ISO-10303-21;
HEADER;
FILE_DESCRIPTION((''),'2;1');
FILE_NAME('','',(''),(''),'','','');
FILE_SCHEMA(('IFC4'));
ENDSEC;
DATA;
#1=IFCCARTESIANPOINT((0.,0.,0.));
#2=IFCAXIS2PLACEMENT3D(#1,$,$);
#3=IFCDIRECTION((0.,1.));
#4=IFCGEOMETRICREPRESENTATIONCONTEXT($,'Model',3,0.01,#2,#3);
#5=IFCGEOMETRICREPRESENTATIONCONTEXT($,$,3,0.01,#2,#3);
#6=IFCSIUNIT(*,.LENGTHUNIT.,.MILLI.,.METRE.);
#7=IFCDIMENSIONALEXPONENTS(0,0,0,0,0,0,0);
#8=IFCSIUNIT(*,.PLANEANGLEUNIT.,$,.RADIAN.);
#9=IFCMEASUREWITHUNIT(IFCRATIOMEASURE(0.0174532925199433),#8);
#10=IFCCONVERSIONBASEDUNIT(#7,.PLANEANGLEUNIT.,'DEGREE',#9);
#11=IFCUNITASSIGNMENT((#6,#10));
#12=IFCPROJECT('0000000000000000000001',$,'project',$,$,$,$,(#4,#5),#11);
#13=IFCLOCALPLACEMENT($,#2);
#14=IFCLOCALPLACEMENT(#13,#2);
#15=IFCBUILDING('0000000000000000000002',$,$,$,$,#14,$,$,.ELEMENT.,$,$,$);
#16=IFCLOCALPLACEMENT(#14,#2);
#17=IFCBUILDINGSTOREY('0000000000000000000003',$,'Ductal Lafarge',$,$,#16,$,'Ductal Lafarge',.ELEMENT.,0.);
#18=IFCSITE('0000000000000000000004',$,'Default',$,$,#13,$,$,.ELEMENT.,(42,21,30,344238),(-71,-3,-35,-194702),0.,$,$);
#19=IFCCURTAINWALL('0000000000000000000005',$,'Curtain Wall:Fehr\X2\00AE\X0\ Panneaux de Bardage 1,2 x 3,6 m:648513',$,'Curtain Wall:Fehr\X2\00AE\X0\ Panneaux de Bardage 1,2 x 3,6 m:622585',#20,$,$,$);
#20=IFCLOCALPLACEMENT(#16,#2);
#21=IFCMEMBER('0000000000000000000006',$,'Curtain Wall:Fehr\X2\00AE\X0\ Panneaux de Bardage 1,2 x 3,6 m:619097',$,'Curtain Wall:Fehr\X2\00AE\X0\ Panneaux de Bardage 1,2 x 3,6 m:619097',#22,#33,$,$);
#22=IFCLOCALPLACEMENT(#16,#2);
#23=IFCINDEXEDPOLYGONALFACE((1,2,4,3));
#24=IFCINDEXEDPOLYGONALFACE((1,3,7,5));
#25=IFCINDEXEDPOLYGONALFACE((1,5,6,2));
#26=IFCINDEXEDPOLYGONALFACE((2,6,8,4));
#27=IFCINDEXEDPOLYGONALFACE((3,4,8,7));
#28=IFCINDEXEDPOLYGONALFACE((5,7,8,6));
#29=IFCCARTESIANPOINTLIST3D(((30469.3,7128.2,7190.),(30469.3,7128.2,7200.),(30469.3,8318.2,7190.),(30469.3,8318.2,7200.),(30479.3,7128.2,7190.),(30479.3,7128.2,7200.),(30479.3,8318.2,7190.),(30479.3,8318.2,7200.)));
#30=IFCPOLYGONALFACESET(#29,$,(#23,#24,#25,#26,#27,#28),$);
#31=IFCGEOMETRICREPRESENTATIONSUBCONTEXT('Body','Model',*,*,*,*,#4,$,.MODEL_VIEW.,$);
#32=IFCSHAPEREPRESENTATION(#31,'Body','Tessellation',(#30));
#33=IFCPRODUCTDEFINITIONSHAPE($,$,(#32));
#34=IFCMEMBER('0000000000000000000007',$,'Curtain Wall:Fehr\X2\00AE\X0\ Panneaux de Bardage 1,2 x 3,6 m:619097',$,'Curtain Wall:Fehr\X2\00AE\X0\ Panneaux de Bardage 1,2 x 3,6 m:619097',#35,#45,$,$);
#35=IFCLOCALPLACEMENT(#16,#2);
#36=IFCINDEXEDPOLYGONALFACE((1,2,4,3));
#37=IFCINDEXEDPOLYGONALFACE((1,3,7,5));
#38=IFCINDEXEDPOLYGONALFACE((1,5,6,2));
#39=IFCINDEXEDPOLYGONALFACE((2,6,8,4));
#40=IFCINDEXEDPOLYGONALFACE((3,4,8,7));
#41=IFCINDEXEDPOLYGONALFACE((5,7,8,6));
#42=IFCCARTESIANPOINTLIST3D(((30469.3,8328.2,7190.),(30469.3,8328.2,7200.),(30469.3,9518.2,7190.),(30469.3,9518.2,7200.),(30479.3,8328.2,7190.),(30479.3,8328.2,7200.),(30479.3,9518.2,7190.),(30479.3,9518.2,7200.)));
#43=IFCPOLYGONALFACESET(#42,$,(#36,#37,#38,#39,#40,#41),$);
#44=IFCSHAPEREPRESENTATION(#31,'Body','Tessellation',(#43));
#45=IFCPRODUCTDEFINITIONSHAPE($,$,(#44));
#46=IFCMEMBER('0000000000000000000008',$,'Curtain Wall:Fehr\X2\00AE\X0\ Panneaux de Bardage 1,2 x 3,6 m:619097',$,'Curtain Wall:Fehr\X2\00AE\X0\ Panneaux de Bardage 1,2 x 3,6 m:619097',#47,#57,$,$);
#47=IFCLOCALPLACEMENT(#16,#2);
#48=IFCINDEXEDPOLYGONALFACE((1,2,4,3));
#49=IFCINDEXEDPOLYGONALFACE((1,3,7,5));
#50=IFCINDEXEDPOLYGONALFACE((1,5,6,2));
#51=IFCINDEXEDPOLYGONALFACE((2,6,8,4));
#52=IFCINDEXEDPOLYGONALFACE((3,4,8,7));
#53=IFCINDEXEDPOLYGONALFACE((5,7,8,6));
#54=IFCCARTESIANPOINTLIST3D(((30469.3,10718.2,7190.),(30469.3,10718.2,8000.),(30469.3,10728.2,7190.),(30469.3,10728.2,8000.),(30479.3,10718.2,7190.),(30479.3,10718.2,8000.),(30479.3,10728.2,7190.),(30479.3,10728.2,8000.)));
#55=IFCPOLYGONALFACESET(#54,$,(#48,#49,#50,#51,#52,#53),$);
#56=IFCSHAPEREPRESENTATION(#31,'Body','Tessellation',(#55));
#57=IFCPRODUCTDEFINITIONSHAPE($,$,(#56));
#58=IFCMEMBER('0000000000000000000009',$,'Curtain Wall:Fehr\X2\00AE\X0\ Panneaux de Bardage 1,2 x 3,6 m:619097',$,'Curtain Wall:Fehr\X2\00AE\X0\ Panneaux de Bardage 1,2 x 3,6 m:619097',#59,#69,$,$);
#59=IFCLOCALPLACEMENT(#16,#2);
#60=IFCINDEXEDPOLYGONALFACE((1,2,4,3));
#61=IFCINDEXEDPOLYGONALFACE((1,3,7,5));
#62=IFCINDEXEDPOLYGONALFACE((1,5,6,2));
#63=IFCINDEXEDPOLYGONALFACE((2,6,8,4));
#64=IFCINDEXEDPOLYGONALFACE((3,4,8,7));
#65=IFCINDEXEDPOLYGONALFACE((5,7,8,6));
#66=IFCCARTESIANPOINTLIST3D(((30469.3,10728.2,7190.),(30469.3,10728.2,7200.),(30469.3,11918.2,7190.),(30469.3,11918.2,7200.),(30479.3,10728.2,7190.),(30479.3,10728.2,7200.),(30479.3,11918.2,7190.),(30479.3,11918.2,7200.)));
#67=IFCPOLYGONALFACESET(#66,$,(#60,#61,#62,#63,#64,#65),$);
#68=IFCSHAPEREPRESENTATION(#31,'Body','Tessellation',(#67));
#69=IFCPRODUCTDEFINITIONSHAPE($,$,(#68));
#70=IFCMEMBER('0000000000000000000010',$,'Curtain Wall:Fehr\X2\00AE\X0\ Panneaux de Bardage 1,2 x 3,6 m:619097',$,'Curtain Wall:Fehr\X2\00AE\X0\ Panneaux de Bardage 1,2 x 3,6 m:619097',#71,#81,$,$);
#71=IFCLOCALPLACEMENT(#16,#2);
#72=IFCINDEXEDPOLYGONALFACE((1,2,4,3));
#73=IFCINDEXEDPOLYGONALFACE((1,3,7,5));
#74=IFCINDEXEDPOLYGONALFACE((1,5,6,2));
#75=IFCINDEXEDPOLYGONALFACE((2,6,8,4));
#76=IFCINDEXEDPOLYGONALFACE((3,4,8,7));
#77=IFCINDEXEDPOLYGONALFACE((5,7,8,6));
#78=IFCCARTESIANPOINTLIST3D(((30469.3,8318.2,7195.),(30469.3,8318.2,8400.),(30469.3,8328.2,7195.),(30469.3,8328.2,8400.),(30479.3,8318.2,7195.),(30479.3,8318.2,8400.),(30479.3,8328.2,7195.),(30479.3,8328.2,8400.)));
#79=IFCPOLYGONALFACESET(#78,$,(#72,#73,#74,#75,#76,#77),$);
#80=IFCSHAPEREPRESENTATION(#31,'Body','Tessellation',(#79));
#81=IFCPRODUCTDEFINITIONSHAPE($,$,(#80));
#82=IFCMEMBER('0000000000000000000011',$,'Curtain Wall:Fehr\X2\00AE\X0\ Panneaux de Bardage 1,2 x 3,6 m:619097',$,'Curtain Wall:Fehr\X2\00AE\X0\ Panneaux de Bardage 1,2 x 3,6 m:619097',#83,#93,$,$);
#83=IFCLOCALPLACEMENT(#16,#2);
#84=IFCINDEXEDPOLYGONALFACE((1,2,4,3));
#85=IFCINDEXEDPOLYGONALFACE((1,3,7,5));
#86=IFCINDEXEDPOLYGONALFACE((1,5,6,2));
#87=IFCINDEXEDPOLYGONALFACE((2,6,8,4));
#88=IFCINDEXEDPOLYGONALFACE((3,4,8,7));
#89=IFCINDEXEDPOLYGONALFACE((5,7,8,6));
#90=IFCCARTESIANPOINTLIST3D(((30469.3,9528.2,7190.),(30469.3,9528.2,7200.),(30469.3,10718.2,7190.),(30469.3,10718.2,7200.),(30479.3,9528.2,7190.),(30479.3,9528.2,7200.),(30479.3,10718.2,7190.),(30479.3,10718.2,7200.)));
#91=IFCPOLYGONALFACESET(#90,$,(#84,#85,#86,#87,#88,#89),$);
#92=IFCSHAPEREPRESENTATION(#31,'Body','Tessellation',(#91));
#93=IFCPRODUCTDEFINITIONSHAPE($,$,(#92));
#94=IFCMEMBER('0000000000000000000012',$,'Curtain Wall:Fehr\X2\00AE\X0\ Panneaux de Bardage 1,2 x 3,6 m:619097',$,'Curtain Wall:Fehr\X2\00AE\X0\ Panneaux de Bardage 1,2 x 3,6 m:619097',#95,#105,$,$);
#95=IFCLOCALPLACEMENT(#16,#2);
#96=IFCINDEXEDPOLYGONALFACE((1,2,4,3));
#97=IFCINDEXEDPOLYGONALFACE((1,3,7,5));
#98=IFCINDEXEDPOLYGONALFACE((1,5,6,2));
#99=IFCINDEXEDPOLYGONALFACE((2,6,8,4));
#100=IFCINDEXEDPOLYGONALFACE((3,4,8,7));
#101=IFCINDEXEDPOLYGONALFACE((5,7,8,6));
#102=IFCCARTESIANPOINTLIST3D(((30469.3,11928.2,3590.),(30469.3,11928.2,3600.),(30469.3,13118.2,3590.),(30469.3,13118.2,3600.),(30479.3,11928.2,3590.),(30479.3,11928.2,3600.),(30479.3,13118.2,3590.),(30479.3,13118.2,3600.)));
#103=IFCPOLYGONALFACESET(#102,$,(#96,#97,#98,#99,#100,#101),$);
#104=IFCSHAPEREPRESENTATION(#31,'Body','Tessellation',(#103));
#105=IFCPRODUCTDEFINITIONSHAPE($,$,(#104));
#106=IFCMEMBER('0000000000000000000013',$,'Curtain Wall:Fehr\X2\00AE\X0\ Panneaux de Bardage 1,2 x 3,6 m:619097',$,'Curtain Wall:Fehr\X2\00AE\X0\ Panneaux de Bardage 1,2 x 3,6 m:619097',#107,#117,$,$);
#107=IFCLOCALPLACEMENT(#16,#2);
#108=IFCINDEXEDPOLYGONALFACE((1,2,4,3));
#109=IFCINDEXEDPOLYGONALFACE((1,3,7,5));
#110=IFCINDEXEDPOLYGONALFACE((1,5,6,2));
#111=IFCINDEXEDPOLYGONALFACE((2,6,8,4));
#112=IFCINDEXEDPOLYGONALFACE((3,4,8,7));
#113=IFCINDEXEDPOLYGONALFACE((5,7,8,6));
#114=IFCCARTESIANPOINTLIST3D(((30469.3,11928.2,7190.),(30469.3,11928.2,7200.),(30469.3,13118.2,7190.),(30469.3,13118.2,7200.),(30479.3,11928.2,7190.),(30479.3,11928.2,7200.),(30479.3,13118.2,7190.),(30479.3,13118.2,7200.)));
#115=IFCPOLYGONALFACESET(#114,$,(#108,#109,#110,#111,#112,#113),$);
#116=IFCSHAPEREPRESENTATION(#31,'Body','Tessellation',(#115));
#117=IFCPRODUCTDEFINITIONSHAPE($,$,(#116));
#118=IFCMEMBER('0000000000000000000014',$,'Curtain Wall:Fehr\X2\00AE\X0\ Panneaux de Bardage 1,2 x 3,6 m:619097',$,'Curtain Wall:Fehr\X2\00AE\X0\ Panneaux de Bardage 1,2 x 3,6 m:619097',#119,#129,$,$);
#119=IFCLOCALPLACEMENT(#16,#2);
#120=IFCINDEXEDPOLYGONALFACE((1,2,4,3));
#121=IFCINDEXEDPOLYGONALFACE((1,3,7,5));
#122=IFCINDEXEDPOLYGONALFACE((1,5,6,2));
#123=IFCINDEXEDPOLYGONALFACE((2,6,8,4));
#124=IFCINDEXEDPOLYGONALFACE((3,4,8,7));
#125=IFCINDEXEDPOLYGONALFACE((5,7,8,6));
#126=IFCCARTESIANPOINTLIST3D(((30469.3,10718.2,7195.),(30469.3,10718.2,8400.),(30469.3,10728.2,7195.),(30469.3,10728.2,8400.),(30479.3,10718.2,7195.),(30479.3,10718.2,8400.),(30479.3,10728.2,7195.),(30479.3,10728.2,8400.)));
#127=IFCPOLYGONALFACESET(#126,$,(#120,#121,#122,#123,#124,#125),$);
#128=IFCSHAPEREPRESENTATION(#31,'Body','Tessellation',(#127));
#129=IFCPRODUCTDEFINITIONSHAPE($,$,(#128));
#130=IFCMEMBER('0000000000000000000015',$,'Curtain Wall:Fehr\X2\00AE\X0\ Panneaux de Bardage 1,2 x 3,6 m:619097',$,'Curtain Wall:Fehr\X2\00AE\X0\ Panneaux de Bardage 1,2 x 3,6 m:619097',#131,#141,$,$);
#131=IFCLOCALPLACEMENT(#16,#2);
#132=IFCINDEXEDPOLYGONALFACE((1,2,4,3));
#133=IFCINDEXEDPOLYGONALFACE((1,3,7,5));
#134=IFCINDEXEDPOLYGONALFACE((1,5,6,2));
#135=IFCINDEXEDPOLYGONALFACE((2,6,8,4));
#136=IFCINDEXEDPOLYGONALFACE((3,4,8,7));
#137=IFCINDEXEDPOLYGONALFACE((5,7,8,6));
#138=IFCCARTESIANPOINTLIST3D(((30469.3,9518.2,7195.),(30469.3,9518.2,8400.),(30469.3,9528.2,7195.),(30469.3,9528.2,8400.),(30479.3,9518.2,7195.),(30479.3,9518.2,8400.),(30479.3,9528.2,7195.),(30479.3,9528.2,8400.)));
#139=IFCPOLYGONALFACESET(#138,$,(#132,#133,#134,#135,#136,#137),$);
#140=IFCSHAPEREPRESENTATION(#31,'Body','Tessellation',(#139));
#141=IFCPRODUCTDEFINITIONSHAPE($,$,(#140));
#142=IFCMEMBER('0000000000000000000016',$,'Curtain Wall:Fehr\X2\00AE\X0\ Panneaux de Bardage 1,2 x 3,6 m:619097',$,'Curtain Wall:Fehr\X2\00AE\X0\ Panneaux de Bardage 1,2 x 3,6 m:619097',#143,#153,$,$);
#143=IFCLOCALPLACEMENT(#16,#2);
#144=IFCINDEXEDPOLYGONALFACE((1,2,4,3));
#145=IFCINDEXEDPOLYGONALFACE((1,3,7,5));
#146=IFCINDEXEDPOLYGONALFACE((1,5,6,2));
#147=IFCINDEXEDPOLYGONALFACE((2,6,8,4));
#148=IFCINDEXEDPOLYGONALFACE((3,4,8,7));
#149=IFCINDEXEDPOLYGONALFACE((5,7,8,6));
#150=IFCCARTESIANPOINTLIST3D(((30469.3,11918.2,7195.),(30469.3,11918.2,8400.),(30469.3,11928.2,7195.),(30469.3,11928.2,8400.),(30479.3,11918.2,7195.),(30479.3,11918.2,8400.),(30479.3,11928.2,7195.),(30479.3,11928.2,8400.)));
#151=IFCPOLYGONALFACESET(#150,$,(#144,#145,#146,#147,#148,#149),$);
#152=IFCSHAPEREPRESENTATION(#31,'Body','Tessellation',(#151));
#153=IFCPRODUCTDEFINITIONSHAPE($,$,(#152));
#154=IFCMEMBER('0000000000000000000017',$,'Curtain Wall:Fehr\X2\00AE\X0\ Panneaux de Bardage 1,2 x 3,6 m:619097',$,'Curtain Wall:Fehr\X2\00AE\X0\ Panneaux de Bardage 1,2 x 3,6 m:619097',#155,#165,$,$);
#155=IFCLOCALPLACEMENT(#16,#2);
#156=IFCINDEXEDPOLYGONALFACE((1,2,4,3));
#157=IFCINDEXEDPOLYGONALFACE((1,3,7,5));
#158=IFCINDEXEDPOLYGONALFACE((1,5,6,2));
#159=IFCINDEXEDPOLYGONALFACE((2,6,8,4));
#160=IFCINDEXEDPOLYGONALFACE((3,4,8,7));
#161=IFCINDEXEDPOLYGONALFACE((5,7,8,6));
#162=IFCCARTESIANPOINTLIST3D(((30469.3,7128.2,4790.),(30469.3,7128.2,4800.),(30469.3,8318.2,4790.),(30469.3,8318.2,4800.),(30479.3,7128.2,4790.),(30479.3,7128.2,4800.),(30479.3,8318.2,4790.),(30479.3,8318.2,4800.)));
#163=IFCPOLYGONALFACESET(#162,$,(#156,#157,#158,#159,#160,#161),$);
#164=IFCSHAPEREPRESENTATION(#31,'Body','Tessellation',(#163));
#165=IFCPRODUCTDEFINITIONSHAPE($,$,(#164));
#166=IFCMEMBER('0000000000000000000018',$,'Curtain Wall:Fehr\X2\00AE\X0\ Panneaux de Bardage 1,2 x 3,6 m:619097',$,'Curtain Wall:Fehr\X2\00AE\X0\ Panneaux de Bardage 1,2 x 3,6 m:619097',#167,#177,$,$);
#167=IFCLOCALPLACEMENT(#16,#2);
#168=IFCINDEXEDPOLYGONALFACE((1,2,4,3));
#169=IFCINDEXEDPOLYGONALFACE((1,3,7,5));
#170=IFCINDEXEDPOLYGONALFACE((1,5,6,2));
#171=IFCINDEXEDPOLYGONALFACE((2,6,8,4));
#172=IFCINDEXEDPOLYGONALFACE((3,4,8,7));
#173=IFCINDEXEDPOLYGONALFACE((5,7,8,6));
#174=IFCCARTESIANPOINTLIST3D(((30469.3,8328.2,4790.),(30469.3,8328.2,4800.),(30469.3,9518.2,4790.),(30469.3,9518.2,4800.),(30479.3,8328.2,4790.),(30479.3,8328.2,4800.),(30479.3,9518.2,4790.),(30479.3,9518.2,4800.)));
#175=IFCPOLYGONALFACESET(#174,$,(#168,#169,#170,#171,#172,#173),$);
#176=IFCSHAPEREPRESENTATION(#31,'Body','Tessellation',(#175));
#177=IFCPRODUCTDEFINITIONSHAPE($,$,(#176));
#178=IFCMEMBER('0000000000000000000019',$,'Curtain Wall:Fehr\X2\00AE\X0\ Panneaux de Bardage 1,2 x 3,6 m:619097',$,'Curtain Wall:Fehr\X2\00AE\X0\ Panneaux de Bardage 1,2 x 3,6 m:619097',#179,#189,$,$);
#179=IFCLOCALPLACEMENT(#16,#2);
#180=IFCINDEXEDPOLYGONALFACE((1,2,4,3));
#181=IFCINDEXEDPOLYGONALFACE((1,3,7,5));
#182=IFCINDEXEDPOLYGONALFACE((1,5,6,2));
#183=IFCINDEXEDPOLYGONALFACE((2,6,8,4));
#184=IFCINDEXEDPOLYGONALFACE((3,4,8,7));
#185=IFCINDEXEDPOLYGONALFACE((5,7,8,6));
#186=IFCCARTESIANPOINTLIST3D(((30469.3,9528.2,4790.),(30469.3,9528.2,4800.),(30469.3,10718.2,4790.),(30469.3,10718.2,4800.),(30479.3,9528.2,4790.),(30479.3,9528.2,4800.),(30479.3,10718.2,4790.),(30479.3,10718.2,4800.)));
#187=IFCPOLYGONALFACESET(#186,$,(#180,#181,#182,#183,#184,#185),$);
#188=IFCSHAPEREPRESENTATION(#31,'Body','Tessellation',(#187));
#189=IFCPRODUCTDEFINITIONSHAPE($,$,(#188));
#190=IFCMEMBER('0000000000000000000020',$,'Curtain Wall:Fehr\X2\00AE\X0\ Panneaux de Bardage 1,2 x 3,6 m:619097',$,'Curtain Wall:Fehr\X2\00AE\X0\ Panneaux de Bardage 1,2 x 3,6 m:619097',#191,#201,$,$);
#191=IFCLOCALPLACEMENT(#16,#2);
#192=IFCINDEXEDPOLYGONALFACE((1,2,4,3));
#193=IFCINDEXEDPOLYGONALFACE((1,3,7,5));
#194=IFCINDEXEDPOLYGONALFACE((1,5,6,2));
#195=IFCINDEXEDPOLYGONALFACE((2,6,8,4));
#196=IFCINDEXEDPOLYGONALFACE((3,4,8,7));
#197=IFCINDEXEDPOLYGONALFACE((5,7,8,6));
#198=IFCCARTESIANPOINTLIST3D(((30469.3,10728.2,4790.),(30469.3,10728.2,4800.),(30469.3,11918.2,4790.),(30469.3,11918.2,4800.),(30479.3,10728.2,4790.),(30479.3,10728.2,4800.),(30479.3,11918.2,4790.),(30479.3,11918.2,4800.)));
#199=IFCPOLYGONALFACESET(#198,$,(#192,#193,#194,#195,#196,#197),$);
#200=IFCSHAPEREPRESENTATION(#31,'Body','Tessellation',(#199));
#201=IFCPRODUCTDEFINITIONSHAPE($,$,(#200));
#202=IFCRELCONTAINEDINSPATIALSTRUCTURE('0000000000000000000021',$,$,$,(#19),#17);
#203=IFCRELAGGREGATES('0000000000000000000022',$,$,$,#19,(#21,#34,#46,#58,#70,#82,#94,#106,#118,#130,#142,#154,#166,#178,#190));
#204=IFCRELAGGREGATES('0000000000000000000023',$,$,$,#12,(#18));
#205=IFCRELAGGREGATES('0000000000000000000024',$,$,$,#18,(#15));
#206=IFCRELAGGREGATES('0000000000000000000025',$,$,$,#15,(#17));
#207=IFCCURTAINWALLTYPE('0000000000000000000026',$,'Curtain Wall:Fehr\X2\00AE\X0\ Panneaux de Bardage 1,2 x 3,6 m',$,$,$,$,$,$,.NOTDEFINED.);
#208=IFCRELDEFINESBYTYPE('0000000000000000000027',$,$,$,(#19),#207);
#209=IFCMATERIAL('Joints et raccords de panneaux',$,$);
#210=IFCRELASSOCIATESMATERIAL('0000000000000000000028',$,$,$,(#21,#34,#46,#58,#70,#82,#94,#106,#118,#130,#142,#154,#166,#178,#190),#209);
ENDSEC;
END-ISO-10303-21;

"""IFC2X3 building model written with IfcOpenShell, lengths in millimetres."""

from ifc_helpers import new_model, entity, si_unit, converted_unit, direction, frame, frame_2d, origin, origin_2d_with_axis, place, context, subcontext, project, spatial, rectangle, extrude, material, type_object, element, aggregate, save


model = new_model("IFC2X3")

# Units and contexts
model_context = context("Model", 3, precision=0.01, world=origin(), true_north=direction((0.0, 1.0)))
context_of_model = context(None, 3, precision=0.01, world=origin(), true_north=direction((0.0, 1.0)))
body_context = subcontext(model_context, "Body", "Model", "MODEL_VIEW")
ifc_project = project(units=[si_unit("LENGTHUNIT", "METRE", prefix="MILLI"), converted_unit("PLANEANGLEUNIT", "DEGREE", entity("IfcRatioMeasure", 0.0174532925199433), si_unit("PLANEANGLEUNIT", "RADIAN"), dimensions=[0, 0, 0, 0, 0, 0, 0])], contexts=[model_context, context_of_model])

# Site, building, storey
site_placement = place(None, origin())
site = spatial("IfcSite", under=ifc_project, at=site_placement, Name="Default", CompositionType="ELEMENT", RefLatitude=(42, 21, 30, 344238), RefLongitude=(-71, -3, -35, -194702), RefElevation=0.0)
building_placement = place(site_placement, origin())
building = spatial("IfcBuilding", under=site, at=building_placement, CompositionType="ELEMENT")
storey_placement = place(building_placement, origin())
storey = spatial("IfcBuildingStorey", under=building, at=storey_placement, Name="Ductal Lafarge", LongName="Ductal Lafarge", CompositionType="ELEMENT", Elevation=0.0)

# Curtain wall, members
curtain_wall_type = type_object("IfcCurtainWallType", Name="Curtain Wall:Fehr® Panneaux de Bardage 1,2 x 3,6 m", PredefinedType="NOTDEFINED")
curtain_wall_placement = place(storey_placement, origin())
curtain_wall = element("IfcCurtainWall", 1, at=curtain_wall_placement, inside=storey, type_object=curtain_wall_type, Name="Curtain Wall:Fehr® Panneaux de Bardage 1,2 x 3,6 m:648513", ObjectType="Curtain Wall:Fehr® Panneaux de Bardage 1,2 x 3,6 m:622585")
ifc_material_1 = material(Name="Joints et raccords de panneaux")
member_1_placement = place(curtain_wall_placement, frame((30469.3, 7128.2, 7190.0)))
member_1 = element("IfcMember", 2, at=member_1_placement, material=ifc_material_1, Name="Curtain Wall:Fehr® Panneaux de Bardage 1,2 x 3,6 m:619097", ObjectType="Curtain Wall:Fehr® Panneaux de Bardage 1,2 x 3,6 m:619097", context=body_context, shape_type="SweptSolid", body=[
    extrude(rectangle(XDim=1190.0, YDim=10.0, at=origin_2d_with_axis()), frame((5.0, 595.0, 0.0), z_axis=(0.0, 0.0, 1.0), x_axis=(0.0, -1.0, 0.0)), (0.0, 0.0, 1.0), 10.0),
])
member_2_placement = place(curtain_wall_placement, frame((30469.3, 8328.2, 7190.0)))
member_2 = element("IfcMember", 3, at=member_2_placement, material=ifc_material_1, Name="Curtain Wall:Fehr® Panneaux de Bardage 1,2 x 3,6 m:619097", ObjectType="Curtain Wall:Fehr® Panneaux de Bardage 1,2 x 3,6 m:619097", context=body_context, shape_type="SweptSolid", body=[
    extrude(rectangle(XDim=1190.0, YDim=10.0, at=frame_2d((0.0, 0.0), x_axis=(1.0, 0.0))), frame((5.0, 595.0, 0.0), z_axis=(0.0, 0.0, 1.0), x_axis=(0.0, -1.0, 0.0)), (0.0, 0.0, 1.0), 10.0),
])
member_3_placement = place(curtain_wall_placement, frame((30469.3, 10718.2, 7190.0)))
member_3 = element("IfcMember", 4, at=member_3_placement, material=ifc_material_1, Name="Curtain Wall:Fehr® Panneaux de Bardage 1,2 x 3,6 m:619097", ObjectType="Curtain Wall:Fehr® Panneaux de Bardage 1,2 x 3,6 m:619097", context=body_context, shape_type="SweptSolid", body=[
    extrude(rectangle(XDim=10.0, YDim=10.0, at=frame_2d((0.0, 0.0), x_axis=(1.0, 0.0))), frame((5.0, 5.0, 0.0), z_axis=(0.0, 0.0, 1.0), x_axis=(-1.0, 0.0, 0.0)), (0.0, 0.0, 1.0), 810.0),
])
member_4_placement = place(curtain_wall_placement, frame((30469.3, 10728.2, 7190.0)))
member_4 = element("IfcMember", 5, at=member_4_placement, material=ifc_material_1, Name="Curtain Wall:Fehr® Panneaux de Bardage 1,2 x 3,6 m:619097", ObjectType="Curtain Wall:Fehr® Panneaux de Bardage 1,2 x 3,6 m:619097", context=body_context, shape_type="SweptSolid", body=[
    extrude(rectangle(XDim=1190.0, YDim=10.0, at=frame_2d((0.0, 0.0), x_axis=(1.0, 0.0))), frame((5.0, 595.0, 0.0), z_axis=(0.0, 0.0, 1.0), x_axis=(0.0, -1.0, 0.0)), (0.0, 0.0, 1.0), 10.0),
])
member_5_placement = place(curtain_wall_placement, frame((30469.3, 8318.2, 7195.0)))
member_5 = element("IfcMember", 6, at=member_5_placement, material=ifc_material_1, Name="Curtain Wall:Fehr® Panneaux de Bardage 1,2 x 3,6 m:619097", ObjectType="Curtain Wall:Fehr® Panneaux de Bardage 1,2 x 3,6 m:619097", context=body_context, shape_type="SweptSolid", body=[
    extrude(rectangle(XDim=10.0, YDim=10.0, at=frame_2d((0.0, 0.0), x_axis=(1.0, 0.0))), frame((5.0, 5.0, 0.0), z_axis=(0.0, 0.0, 1.0), x_axis=(-1.0, 0.0, 0.0)), (0.0, 0.0, 1.0), 1205.0),
])
member_6_placement = place(curtain_wall_placement, frame((30469.3, 9528.2, 7190.0)))
member_6 = element("IfcMember", 7, at=member_6_placement, material=ifc_material_1, Name="Curtain Wall:Fehr® Panneaux de Bardage 1,2 x 3,6 m:619097", ObjectType="Curtain Wall:Fehr® Panneaux de Bardage 1,2 x 3,6 m:619097", context=body_context, shape_type="SweptSolid", body=[
    extrude(rectangle(XDim=1190.0, YDim=10.0, at=frame_2d((0.0, 0.0), x_axis=(1.0, 0.0))), frame((5.0, 595.0, 0.0), z_axis=(0.0, 0.0, 1.0), x_axis=(0.0, -1.0, 0.0)), (0.0, 0.0, 1.0), 10.0),
])
member_7_placement = place(curtain_wall_placement, frame((30469.3, 11928.2, 3590.0)))
member_7 = element("IfcMember", 8, at=member_7_placement, material=ifc_material_1, Name="Curtain Wall:Fehr® Panneaux de Bardage 1,2 x 3,6 m:619097", ObjectType="Curtain Wall:Fehr® Panneaux de Bardage 1,2 x 3,6 m:619097", context=body_context, shape_type="SweptSolid", body=[
    extrude(rectangle(XDim=1190.0, YDim=10.0, at=frame_2d((0.0, 0.0), x_axis=(1.0, 0.0))), frame((5.0, 595.0, 0.0), z_axis=(0.0, 0.0, 1.0), x_axis=(0.0, -1.0, 0.0)), (0.0, 0.0, 1.0), 10.0),
])
member_8_placement = place(curtain_wall_placement, frame((30469.3, 11928.2, 7190.0)))
member_8 = element("IfcMember", 9, at=member_8_placement, material=ifc_material_1, Name="Curtain Wall:Fehr® Panneaux de Bardage 1,2 x 3,6 m:619097", ObjectType="Curtain Wall:Fehr® Panneaux de Bardage 1,2 x 3,6 m:619097", context=body_context, shape_type="SweptSolid", body=[
    extrude(rectangle(XDim=1190.0, YDim=10.0, at=frame_2d((0.0, 0.0), x_axis=(1.0, 0.0))), frame((5.0, 595.0, 0.0), z_axis=(0.0, 0.0, 1.0), x_axis=(0.0, -1.0, 0.0)), (0.0, 0.0, 1.0), 10.0),
])
member_9_placement = place(curtain_wall_placement, frame((30469.3, 10718.2, 7195.0)))
member_9 = element("IfcMember", 10, at=member_9_placement, material=ifc_material_1, Name="Curtain Wall:Fehr® Panneaux de Bardage 1,2 x 3,6 m:619097", ObjectType="Curtain Wall:Fehr® Panneaux de Bardage 1,2 x 3,6 m:619097", context=body_context, shape_type="SweptSolid", body=[
    extrude(rectangle(XDim=10.0, YDim=10.0, at=frame_2d((0.0, 0.0), x_axis=(1.0, 0.0))), frame((5.0, 5.0, 0.0), z_axis=(0.0, 0.0, 1.0), x_axis=(-1.0, 0.0, 0.0)), (0.0, 0.0, 1.0), 1205.0),
])
member_10_placement = place(curtain_wall_placement, frame((30469.3, 9518.2, 7195.0)))
member_10 = element("IfcMember", 11, at=member_10_placement, material=ifc_material_1, Name="Curtain Wall:Fehr® Panneaux de Bardage 1,2 x 3,6 m:619097", ObjectType="Curtain Wall:Fehr® Panneaux de Bardage 1,2 x 3,6 m:619097", context=body_context, shape_type="SweptSolid", body=[
    extrude(rectangle(XDim=10.0, YDim=10.0, at=frame_2d((0.0, 0.0), x_axis=(1.0, 0.0))), frame((5.0, 5.0, 0.0), z_axis=(0.0, 0.0, 1.0), x_axis=(-1.0, 0.0, 0.0)), (0.0, 0.0, 1.0), 1205.0),
])
member_11_placement = place(curtain_wall_placement, frame((30469.3, 11918.2, 7195.0)))
member_11 = element("IfcMember", 12, at=member_11_placement, material=ifc_material_1, Name="Curtain Wall:Fehr® Panneaux de Bardage 1,2 x 3,6 m:619097", ObjectType="Curtain Wall:Fehr® Panneaux de Bardage 1,2 x 3,6 m:619097", context=body_context, shape_type="SweptSolid", body=[
    extrude(rectangle(XDim=10.0, YDim=10.0, at=frame_2d((0.0, 0.0), x_axis=(1.0, 0.0))), frame((5.0, 5.0, 0.0), z_axis=(0.0, 0.0, 1.0), x_axis=(-1.0, 0.0, 0.0)), (0.0, 0.0, 1.0), 1205.0),
])
member_12_placement = place(curtain_wall_placement, frame((30469.3, 7128.2, 4790.0)))
member_12 = element("IfcMember", 13, at=member_12_placement, material=ifc_material_1, Name="Curtain Wall:Fehr® Panneaux de Bardage 1,2 x 3,6 m:619097", ObjectType="Curtain Wall:Fehr® Panneaux de Bardage 1,2 x 3,6 m:619097", context=body_context, shape_type="SweptSolid", body=[
    extrude(rectangle(XDim=1190.0, YDim=10.0, at=origin_2d_with_axis()), frame((5.0, 595.0, 0.0), z_axis=(0.0, 0.0, 1.0), x_axis=(0.0, -1.0, 0.0)), (0.0, 0.0, 1.0), 10.0),
])
member_13_placement = place(curtain_wall_placement, frame((30469.3, 8328.2, 4790.0)))
member_13 = element("IfcMember", 14, at=member_13_placement, material=ifc_material_1, Name="Curtain Wall:Fehr® Panneaux de Bardage 1,2 x 3,6 m:619097", ObjectType="Curtain Wall:Fehr® Panneaux de Bardage 1,2 x 3,6 m:619097", context=body_context, shape_type="SweptSolid", body=[
    extrude(rectangle(XDim=1190.0, YDim=10.0, at=frame_2d((0.0, 0.0), x_axis=(1.0, 0.0))), frame((5.0, 595.0, 0.0), z_axis=(0.0, 0.0, 1.0), x_axis=(0.0, -1.0, 0.0)), (0.0, 0.0, 1.0), 10.0),
])
member_14_placement = place(curtain_wall_placement, frame((30469.3, 9528.2, 4790.0)))
member_14 = element("IfcMember", 15, at=member_14_placement, material=ifc_material_1, Name="Curtain Wall:Fehr® Panneaux de Bardage 1,2 x 3,6 m:619097", ObjectType="Curtain Wall:Fehr® Panneaux de Bardage 1,2 x 3,6 m:619097", context=body_context, shape_type="SweptSolid", body=[
    extrude(rectangle(XDim=1190.0, YDim=10.0, at=frame_2d((0.0, 0.0), x_axis=(1.0, 0.0))), frame((5.0, 595.0, 0.0), z_axis=(0.0, 0.0, 1.0), x_axis=(0.0, -1.0, 0.0)), (0.0, 0.0, 1.0), 10.0),
])
member_15_placement = place(curtain_wall_placement, frame((30469.3, 10728.2, 4790.0)))
member_15 = element("IfcMember", 16, at=member_15_placement, material=ifc_material_1, Name="Curtain Wall:Fehr® Panneaux de Bardage 1,2 x 3,6 m:619097", ObjectType="Curtain Wall:Fehr® Panneaux de Bardage 1,2 x 3,6 m:619097", context=body_context, shape_type="SweptSolid", body=[
    extrude(rectangle(XDim=1190.0, YDim=10.0, at=frame_2d((0.0, 0.0), x_axis=(1.0, 0.0))), frame((5.0, 595.0, 0.0), z_axis=(0.0, 0.0, 1.0), x_axis=(0.0, -1.0, 0.0)), (0.0, 0.0, 1.0), 10.0),
])
aggregate(curtain_wall, [member_1, member_2, member_3, member_4, member_5, member_6, member_7, member_8, member_9, member_10, member_11, member_12, member_13, member_14, member_15])

save(model, "model.ifc")
